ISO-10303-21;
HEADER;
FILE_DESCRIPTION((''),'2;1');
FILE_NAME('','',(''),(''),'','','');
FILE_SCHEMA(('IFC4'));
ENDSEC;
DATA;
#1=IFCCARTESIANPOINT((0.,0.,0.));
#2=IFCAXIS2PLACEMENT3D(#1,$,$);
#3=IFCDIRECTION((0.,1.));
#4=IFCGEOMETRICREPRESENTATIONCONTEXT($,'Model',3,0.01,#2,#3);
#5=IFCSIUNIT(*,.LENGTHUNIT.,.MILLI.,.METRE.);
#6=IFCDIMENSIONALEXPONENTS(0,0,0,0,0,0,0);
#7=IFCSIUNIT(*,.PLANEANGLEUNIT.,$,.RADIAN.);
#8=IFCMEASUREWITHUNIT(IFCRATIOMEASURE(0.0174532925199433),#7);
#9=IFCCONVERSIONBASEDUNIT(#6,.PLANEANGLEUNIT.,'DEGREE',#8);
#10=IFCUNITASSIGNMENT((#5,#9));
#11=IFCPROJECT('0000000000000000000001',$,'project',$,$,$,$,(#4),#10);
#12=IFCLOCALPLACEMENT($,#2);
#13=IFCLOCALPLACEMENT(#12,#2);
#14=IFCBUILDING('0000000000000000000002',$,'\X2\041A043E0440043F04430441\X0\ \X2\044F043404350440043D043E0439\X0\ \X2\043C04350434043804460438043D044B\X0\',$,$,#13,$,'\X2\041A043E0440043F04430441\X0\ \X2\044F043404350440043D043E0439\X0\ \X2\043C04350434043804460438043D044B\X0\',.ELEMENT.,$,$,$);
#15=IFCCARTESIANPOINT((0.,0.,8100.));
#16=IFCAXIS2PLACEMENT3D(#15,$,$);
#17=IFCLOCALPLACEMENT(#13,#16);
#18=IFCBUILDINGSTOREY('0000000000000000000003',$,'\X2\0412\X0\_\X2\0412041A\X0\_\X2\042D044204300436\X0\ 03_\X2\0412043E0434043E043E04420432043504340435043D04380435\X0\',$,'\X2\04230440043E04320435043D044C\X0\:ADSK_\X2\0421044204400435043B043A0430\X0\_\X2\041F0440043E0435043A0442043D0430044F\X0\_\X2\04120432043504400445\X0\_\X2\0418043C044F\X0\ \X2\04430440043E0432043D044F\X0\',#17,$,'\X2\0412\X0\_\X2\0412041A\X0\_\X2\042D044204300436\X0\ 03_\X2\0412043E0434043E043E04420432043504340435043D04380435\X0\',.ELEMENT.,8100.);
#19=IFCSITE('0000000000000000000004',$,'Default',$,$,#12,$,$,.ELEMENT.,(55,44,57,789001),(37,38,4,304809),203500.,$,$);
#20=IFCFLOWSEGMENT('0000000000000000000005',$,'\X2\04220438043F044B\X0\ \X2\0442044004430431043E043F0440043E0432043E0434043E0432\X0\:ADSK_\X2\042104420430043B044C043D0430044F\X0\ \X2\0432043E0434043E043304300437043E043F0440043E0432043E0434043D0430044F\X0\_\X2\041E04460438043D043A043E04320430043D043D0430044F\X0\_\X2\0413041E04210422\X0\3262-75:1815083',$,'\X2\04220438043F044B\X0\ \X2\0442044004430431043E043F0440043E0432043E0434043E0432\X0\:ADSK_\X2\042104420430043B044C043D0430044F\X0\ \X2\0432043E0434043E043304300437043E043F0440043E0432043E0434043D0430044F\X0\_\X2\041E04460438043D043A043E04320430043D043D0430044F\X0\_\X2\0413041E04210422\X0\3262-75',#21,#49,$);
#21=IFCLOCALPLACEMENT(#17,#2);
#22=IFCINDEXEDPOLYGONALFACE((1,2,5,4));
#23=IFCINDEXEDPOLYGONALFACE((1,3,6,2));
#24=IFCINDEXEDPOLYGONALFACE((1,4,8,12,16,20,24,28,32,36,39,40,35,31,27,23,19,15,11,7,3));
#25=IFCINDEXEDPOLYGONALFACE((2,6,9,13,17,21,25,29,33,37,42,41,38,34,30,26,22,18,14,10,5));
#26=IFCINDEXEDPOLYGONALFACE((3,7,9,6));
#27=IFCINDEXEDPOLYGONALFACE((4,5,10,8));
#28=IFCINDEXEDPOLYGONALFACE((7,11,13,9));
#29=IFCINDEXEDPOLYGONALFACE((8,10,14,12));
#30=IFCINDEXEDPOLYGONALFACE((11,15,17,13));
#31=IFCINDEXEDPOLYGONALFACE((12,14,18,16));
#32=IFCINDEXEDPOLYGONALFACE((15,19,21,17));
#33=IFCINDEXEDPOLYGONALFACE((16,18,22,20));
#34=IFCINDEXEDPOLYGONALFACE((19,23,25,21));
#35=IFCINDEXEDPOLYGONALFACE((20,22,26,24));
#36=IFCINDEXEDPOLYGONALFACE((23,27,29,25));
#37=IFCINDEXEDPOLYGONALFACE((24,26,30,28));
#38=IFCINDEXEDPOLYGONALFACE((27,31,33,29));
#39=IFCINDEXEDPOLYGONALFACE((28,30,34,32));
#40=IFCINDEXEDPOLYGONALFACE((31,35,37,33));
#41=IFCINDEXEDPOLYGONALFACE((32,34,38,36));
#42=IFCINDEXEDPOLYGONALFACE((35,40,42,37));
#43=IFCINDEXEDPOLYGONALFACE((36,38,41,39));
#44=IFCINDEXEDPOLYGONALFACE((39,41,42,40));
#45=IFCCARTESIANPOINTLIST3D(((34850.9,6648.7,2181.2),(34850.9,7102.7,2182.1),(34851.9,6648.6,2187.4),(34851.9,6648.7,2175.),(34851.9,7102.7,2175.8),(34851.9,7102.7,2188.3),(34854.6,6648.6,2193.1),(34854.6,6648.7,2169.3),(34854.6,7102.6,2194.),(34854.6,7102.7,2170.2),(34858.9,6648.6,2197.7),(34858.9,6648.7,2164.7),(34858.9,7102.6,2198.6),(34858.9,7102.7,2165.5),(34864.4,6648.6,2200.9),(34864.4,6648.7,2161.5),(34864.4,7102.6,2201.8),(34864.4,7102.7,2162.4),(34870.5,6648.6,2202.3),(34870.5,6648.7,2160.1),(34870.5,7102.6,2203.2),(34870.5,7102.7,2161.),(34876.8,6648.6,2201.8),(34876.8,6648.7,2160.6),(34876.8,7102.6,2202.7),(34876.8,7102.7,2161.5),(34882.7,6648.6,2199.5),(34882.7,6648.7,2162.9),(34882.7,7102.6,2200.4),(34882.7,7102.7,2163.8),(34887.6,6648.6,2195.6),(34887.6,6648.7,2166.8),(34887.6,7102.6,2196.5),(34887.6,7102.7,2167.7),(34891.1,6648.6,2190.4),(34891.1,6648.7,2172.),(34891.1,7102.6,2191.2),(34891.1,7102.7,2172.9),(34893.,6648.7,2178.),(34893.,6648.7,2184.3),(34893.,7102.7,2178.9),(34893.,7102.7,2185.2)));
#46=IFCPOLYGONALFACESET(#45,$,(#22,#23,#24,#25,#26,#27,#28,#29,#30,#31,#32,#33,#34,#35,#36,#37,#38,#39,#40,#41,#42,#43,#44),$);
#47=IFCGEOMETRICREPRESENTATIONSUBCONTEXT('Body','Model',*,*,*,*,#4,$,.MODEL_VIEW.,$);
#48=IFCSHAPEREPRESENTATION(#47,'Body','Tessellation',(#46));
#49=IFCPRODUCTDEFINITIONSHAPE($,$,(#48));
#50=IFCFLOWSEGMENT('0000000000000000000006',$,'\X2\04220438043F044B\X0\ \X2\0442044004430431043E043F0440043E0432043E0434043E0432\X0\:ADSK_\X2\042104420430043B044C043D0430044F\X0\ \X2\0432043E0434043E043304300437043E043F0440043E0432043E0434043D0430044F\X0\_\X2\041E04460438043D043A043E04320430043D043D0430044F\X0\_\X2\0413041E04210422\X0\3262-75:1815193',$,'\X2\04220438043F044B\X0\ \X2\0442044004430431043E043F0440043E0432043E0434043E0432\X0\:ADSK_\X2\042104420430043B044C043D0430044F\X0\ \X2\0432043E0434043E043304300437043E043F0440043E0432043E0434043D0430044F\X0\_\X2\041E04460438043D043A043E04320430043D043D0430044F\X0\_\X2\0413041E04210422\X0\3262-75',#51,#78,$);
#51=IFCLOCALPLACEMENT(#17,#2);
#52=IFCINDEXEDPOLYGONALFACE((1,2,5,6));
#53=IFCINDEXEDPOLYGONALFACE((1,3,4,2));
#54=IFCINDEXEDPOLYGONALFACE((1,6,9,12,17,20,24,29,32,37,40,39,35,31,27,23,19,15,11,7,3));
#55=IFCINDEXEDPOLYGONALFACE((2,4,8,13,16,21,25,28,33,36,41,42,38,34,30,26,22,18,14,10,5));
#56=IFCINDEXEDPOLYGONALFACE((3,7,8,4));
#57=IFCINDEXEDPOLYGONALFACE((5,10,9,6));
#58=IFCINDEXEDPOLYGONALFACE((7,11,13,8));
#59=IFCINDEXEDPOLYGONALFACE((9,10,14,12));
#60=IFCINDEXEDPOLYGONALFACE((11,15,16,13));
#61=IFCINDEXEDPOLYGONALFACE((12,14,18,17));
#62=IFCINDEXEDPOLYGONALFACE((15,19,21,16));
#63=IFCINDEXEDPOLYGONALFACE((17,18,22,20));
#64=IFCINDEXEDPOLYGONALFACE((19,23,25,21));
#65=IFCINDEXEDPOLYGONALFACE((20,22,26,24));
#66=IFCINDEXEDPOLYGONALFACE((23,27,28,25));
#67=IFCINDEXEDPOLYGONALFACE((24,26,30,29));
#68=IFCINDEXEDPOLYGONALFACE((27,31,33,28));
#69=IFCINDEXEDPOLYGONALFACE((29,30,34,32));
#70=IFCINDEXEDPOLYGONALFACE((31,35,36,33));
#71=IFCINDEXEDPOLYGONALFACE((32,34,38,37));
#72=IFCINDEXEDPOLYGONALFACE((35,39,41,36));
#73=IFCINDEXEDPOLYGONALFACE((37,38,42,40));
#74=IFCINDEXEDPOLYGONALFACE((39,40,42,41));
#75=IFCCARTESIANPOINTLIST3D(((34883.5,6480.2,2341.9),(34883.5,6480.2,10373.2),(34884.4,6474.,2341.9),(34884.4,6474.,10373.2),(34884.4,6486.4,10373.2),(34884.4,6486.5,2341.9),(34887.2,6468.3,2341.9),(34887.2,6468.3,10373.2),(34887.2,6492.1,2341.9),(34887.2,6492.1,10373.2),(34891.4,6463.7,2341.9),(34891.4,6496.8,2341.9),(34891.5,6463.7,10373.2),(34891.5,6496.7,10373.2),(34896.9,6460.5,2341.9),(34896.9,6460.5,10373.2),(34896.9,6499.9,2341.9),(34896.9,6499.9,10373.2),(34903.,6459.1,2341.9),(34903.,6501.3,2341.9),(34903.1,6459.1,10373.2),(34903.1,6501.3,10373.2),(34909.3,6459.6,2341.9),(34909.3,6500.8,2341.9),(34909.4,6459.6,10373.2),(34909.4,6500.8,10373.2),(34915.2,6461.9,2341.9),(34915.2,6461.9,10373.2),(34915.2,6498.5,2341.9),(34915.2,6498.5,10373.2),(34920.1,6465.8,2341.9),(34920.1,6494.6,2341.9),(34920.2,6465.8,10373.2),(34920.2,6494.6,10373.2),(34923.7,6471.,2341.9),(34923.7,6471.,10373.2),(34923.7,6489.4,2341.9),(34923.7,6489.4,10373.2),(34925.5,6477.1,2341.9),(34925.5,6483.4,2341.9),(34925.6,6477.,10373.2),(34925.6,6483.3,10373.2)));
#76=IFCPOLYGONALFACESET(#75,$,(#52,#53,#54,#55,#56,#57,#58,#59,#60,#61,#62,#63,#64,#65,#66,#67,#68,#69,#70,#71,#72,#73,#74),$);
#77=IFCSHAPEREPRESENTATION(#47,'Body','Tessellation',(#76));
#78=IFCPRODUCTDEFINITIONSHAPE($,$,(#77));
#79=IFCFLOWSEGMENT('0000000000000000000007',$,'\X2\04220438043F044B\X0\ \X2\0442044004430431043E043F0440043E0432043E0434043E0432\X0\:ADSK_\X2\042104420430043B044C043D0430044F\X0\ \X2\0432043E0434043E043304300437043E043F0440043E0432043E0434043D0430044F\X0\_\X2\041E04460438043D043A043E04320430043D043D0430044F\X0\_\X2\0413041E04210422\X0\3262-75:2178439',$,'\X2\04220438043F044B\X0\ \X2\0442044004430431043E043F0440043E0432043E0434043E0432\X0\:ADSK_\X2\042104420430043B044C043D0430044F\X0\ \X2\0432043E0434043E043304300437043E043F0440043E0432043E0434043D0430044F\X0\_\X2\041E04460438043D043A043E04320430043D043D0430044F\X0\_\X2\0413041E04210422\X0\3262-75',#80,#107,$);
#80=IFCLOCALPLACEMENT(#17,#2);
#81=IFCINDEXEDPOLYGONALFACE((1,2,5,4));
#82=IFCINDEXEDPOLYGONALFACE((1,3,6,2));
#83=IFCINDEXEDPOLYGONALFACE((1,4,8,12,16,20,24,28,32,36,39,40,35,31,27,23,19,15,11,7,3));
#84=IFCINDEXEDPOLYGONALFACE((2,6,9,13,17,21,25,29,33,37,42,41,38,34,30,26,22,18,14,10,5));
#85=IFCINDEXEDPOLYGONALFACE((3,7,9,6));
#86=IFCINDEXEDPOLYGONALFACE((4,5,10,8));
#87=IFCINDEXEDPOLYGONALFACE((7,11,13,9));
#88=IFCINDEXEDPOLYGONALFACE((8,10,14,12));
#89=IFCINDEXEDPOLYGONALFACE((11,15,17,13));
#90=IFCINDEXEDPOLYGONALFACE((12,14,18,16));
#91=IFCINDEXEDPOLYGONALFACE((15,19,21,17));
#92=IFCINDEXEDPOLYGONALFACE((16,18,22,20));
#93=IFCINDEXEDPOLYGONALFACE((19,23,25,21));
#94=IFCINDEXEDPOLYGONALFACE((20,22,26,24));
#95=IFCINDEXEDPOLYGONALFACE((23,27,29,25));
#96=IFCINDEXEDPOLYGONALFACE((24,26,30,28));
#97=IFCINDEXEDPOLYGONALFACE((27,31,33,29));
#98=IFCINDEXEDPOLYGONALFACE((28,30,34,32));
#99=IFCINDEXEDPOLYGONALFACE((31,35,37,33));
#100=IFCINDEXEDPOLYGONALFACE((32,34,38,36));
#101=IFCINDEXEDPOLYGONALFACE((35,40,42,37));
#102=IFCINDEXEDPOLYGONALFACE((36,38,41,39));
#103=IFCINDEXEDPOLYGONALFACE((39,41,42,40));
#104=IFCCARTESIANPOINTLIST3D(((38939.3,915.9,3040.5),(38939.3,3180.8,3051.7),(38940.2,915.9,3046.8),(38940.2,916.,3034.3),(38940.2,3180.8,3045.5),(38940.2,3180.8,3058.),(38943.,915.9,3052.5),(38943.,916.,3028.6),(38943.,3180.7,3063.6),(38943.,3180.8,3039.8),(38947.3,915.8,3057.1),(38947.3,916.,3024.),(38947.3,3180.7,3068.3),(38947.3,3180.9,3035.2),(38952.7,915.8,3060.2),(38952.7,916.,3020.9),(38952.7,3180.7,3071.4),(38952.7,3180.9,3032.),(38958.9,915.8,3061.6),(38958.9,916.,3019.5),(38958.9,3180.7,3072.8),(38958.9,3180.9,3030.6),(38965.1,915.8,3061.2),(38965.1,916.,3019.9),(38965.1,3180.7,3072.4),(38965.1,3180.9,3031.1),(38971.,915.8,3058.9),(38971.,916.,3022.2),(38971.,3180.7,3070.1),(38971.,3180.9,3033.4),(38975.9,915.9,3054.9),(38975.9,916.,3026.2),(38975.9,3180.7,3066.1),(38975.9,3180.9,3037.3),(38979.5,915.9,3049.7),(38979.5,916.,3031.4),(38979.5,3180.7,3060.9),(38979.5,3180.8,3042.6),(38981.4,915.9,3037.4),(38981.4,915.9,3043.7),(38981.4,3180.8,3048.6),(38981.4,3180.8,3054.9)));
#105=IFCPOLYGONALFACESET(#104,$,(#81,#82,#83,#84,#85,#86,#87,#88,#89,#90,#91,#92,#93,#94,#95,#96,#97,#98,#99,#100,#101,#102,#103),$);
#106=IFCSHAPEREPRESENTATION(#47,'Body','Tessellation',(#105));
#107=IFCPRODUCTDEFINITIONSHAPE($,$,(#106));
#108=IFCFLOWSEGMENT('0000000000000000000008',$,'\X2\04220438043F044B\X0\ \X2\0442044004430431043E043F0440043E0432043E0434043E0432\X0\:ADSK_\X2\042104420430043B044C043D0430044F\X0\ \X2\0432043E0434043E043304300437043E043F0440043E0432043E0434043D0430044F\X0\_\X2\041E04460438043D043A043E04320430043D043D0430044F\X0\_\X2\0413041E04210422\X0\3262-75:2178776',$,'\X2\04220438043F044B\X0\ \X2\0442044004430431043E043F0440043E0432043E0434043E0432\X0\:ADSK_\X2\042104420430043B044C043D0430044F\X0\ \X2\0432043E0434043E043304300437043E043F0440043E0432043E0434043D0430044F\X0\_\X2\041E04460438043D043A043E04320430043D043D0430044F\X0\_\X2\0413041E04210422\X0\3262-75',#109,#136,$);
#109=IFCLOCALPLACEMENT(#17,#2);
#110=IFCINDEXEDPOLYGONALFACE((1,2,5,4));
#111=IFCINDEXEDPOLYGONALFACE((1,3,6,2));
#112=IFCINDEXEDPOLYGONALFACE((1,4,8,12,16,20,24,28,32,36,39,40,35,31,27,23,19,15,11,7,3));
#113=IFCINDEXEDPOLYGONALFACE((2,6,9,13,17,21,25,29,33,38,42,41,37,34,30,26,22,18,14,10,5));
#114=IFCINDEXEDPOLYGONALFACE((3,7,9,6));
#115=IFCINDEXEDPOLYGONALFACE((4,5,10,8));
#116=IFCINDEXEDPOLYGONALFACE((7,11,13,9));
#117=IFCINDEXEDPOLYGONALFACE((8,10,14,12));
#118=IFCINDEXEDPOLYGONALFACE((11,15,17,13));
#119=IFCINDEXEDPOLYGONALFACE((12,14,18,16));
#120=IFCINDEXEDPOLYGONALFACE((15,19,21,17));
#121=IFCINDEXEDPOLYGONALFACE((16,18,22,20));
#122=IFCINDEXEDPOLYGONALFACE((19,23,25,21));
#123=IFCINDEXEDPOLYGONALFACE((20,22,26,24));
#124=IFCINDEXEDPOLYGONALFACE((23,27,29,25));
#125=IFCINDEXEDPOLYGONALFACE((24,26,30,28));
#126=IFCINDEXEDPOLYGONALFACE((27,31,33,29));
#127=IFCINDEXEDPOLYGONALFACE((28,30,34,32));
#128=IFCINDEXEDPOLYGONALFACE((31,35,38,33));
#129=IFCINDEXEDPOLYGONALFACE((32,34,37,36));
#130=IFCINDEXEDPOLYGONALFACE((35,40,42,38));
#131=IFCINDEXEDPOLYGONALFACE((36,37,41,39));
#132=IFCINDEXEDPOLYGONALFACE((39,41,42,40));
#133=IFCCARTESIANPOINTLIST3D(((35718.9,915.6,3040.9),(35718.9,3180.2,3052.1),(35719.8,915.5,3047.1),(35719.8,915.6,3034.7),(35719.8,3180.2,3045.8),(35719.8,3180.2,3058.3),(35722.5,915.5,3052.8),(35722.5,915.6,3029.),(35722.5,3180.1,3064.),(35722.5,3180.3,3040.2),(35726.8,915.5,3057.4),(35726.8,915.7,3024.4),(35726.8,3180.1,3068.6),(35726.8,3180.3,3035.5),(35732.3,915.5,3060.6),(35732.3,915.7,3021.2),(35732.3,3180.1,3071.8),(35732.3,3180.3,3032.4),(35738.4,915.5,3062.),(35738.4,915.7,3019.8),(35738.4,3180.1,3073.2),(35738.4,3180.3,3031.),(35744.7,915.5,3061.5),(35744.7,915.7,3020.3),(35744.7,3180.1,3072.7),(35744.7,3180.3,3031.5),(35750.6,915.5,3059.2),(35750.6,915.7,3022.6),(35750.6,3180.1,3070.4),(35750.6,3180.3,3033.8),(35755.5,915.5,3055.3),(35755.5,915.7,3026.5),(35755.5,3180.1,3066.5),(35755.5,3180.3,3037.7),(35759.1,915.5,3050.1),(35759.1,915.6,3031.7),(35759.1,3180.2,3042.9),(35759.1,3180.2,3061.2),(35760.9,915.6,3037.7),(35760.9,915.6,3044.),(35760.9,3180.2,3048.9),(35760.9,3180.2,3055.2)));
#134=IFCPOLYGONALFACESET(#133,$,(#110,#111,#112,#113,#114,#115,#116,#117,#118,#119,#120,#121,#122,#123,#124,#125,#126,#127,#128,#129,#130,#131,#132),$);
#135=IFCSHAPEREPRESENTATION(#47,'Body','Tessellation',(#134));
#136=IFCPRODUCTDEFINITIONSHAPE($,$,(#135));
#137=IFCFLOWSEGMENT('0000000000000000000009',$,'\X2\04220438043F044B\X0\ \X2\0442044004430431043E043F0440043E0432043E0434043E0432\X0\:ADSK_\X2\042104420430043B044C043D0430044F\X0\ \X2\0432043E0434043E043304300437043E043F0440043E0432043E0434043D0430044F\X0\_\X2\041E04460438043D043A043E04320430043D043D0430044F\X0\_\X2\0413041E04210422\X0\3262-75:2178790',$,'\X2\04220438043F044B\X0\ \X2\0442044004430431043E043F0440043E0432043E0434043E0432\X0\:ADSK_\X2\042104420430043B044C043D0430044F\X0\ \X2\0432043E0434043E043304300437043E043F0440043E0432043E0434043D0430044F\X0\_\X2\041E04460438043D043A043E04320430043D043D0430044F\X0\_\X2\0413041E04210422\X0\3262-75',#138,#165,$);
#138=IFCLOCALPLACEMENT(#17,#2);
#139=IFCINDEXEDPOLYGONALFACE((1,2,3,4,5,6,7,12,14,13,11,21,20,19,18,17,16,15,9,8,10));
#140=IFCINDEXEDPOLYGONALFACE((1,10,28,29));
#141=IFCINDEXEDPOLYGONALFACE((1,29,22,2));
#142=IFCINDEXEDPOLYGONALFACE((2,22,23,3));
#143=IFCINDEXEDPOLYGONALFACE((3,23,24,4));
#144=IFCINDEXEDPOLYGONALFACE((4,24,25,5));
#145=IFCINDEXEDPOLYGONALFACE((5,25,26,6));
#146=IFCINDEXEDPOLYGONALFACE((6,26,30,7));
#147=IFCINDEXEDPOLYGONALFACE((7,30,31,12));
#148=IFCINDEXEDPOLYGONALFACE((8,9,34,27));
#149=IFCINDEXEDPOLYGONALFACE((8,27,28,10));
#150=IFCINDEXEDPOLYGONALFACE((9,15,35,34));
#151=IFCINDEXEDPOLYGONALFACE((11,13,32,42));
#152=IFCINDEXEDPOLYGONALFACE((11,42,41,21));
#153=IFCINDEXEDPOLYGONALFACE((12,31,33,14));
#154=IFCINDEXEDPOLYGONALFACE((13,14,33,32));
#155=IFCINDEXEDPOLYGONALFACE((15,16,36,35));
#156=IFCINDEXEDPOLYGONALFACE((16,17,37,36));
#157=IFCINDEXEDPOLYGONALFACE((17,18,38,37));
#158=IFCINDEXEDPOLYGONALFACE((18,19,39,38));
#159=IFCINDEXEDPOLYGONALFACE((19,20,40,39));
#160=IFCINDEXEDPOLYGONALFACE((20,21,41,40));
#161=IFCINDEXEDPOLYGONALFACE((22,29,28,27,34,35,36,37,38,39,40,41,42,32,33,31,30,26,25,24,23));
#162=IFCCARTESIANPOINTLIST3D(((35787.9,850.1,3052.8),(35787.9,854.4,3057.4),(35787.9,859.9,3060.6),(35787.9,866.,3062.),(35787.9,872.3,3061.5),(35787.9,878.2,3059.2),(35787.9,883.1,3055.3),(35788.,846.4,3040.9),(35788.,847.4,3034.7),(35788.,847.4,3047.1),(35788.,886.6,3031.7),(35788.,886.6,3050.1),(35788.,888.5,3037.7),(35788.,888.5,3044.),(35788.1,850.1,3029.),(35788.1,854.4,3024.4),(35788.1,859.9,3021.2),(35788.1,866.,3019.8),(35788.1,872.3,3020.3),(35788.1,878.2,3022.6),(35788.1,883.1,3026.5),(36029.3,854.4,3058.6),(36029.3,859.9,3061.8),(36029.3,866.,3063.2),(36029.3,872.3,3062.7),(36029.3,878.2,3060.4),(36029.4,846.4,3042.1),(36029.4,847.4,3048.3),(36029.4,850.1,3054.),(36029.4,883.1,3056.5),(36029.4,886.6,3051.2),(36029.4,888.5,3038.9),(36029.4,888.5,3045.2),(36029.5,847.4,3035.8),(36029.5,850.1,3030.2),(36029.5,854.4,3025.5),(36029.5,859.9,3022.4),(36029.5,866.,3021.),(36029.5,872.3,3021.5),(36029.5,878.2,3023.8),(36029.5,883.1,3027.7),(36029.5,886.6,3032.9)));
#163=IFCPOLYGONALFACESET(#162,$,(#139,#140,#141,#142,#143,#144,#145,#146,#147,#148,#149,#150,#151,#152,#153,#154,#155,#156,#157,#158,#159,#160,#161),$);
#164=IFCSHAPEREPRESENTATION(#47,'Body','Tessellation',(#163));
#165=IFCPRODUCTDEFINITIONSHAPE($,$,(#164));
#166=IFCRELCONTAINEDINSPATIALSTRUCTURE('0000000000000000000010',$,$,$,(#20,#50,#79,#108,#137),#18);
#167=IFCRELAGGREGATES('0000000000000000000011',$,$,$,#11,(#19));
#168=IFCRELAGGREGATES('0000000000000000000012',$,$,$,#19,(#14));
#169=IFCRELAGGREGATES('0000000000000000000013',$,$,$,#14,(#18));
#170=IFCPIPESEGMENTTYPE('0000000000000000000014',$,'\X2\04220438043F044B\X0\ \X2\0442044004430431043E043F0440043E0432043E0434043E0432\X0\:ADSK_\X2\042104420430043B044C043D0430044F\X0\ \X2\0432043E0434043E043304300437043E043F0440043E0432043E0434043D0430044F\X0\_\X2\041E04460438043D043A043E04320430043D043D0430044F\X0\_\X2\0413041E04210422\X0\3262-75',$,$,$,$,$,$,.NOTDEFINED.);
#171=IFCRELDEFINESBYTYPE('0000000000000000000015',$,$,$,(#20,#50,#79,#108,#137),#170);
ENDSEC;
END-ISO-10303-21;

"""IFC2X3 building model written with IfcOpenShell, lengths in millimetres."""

from ifc_helpers import new_model, entity, si_unit, converted_unit, direction, frame, origin, origin_2d_with_axis, place, context, subcontext, project, spatial, circle, extrude, type_object, element, save


model = new_model("IFC2X3")

# Units and contexts
model_context = context("Model", 3, precision=0.01, world=origin(), true_north=direction((0.0, 1.0)))
body_context = subcontext(model_context, "Body", "Model", "MODEL_VIEW")
ifc_project = project(units=[si_unit("LENGTHUNIT", "METRE", prefix="MILLI"), converted_unit("PLANEANGLEUNIT", "DEGREE", entity("IfcRatioMeasure", 0.0174532925199433), si_unit("PLANEANGLEUNIT", "RADIAN"), dimensions=[0, 0, 0, 0, 0, 0, 0])], contexts=[model_context])

# Site, building, storey
site_placement = place(None, origin())
site = spatial("IfcSite", under=ifc_project, at=site_placement, Name="Default", CompositionType="ELEMENT", RefLatitude=(55, 44, 57, 789001), RefLongitude=(37, 38, 4, 304809), RefElevation=203500.0)
building_placement = place(site_placement, origin())
building = spatial("IfcBuilding", under=site, at=building_placement, Name="Корпус ядерной медицины", LongName="Корпус ядерной медицины", CompositionType="ELEMENT")
storey_placement = place(building_placement, frame((0.0, 0.0, 8100.0)))
storey = spatial("IfcBuildingStorey", under=building, at=storey_placement, Name="В_ВК_Этаж 03_Водоотведение", ObjectType="Уровень:ADSK_Стрелка_Проектная_Вверх_Имя уровня", LongName="В_ВК_Этаж 03_Водоотведение", CompositionType="ELEMENT", Elevation=8100.0)

# Flow segments
pipe_segment_type_1 = type_object("IfcPipeSegmentType", Name="Типы трубопроводов:ADSK_Стальная водогазопроводная_Оцинкованная_ГОСТ3262-75", PredefinedType="NOTDEFINED")
flow_segment_1_placement = place(storey_placement, frame((34849.3, 6648.6, 2158.4)))
element("IfcFlowSegment", 1, at=flow_segment_1_placement, inside=storey, type_object=pipe_segment_type_1, Name="Типы трубопроводов:ADSK_Стальная водогазопроводная_Оцинкованная_ГОСТ3262-75:1815083", ObjectType="Типы трубопроводов:ADSK_Стальная водогазопроводная_Оцинкованная_ГОСТ3262-75", context=body_context, shape_type="SweptSolid", body=[
    extrude(circle(Radius=21.1, at=origin_2d_with_axis()), frame((22.8, 0.0, 22.8), z_axis=(0.0, 0.999998, 0.001945), x_axis=(-1.0, 0.0, 0.0)), (0.0, 0.0, 1.0), 454.0),
])
flow_segment_2_placement = place(storey_placement, frame((34881.9, 6457.4, 2341.9)))
element("IfcFlowSegment", 2, at=flow_segment_2_placement, inside=storey, type_object=pipe_segment_type_1, Name="Типы трубопроводов:ADSK_Стальная водогазопроводная_Оцинкованная_ГОСТ3262-75:1815193", ObjectType="Типы трубопроводов:ADSK_Стальная водогазопроводная_Оцинкованная_ГОСТ3262-75", context=body_context, shape_type="SweptSolid", body=[
    extrude(circle(Radius=21.1, at=origin_2d_with_axis()), frame((22.8, 22.8, 0.0), z_axis=(0.000004, -0.000004, 1.0), x_axis=(-1.0, 0.0, 0.000004)), (0.0, 0.0, 1.0), 8031.3),
])
flow_segment_3_placement = place(storey_placement, frame((38937.7, 915.8, 3017.8)))
element("IfcFlowSegment", 3, at=flow_segment_3_placement, inside=storey, type_object=pipe_segment_type_1, Name="Типы трубопроводов:ADSK_Стальная водогазопроводная_Оцинкованная_ГОСТ3262-75:2178439", ObjectType="Типы трубопроводов:ADSK_Стальная водогазопроводная_Оцинкованная_ГОСТ3262-75", context=body_context, shape_type="SweptSolid", body=[
    extrude(circle(Radius=21.1, at=origin_2d_with_axis()), frame((22.8, 0.1, 22.8), z_axis=(0.0, 0.999988, 0.004938), x_axis=(-1.0, 0.0, 0.0)), (0.0, 0.0, 1.0), 2264.9),
])
flow_segment_4_placement = place(storey_placement, frame((35717.2, 915.5, 3018.1)))
element("IfcFlowSegment", 4, at=flow_segment_4_placement, inside=storey, type_object=pipe_segment_type_1, Name="Типы трубопроводов:ADSK_Стальная водогазопроводная_Оцинкованная_ГОСТ3262-75:2178776", ObjectType="Типы трубопроводов:ADSK_Стальная водогазопроводная_Оцинкованная_ГОСТ3262-75", context=body_context, shape_type="SweptSolid", body=[
    extrude(circle(Radius=21.1, at=origin_2d_with_axis()), frame((22.8, 0.1, 22.8), z_axis=(0.0, 0.999988, 0.004938), x_axis=(-1.0, 0.0, 0.0)), (0.0, 0.0, 1.0), 2264.7),
])
flow_segment_5_placement = place(storey_placement, frame((35787.9, 844.8, 3018.1)))
element("IfcFlowSegment", 5, at=flow_segment_5_placement, inside=storey, type_object=pipe_segment_type_1, Name="Типы трубопроводов:ADSK_Стальная водогазопроводная_Оцинкованная_ГОСТ3262-75:2178790", ObjectType="Типы трубопроводов:ADSK_Стальная водогазопроводная_Оцинкованная_ГОСТ3262-75", context=body_context, shape_type="SweptSolid", body=[
    extrude(circle(Radius=21.1, at=origin_2d_with_axis()), frame((0.1, 22.8, 22.8), z_axis=(0.999988, -0.000005, 0.00489), x_axis=(-0.000005, -1.0, 0.0)), (0.0, 0.0, 1.0), 241.4),
])

save(model, "model.ifc")
